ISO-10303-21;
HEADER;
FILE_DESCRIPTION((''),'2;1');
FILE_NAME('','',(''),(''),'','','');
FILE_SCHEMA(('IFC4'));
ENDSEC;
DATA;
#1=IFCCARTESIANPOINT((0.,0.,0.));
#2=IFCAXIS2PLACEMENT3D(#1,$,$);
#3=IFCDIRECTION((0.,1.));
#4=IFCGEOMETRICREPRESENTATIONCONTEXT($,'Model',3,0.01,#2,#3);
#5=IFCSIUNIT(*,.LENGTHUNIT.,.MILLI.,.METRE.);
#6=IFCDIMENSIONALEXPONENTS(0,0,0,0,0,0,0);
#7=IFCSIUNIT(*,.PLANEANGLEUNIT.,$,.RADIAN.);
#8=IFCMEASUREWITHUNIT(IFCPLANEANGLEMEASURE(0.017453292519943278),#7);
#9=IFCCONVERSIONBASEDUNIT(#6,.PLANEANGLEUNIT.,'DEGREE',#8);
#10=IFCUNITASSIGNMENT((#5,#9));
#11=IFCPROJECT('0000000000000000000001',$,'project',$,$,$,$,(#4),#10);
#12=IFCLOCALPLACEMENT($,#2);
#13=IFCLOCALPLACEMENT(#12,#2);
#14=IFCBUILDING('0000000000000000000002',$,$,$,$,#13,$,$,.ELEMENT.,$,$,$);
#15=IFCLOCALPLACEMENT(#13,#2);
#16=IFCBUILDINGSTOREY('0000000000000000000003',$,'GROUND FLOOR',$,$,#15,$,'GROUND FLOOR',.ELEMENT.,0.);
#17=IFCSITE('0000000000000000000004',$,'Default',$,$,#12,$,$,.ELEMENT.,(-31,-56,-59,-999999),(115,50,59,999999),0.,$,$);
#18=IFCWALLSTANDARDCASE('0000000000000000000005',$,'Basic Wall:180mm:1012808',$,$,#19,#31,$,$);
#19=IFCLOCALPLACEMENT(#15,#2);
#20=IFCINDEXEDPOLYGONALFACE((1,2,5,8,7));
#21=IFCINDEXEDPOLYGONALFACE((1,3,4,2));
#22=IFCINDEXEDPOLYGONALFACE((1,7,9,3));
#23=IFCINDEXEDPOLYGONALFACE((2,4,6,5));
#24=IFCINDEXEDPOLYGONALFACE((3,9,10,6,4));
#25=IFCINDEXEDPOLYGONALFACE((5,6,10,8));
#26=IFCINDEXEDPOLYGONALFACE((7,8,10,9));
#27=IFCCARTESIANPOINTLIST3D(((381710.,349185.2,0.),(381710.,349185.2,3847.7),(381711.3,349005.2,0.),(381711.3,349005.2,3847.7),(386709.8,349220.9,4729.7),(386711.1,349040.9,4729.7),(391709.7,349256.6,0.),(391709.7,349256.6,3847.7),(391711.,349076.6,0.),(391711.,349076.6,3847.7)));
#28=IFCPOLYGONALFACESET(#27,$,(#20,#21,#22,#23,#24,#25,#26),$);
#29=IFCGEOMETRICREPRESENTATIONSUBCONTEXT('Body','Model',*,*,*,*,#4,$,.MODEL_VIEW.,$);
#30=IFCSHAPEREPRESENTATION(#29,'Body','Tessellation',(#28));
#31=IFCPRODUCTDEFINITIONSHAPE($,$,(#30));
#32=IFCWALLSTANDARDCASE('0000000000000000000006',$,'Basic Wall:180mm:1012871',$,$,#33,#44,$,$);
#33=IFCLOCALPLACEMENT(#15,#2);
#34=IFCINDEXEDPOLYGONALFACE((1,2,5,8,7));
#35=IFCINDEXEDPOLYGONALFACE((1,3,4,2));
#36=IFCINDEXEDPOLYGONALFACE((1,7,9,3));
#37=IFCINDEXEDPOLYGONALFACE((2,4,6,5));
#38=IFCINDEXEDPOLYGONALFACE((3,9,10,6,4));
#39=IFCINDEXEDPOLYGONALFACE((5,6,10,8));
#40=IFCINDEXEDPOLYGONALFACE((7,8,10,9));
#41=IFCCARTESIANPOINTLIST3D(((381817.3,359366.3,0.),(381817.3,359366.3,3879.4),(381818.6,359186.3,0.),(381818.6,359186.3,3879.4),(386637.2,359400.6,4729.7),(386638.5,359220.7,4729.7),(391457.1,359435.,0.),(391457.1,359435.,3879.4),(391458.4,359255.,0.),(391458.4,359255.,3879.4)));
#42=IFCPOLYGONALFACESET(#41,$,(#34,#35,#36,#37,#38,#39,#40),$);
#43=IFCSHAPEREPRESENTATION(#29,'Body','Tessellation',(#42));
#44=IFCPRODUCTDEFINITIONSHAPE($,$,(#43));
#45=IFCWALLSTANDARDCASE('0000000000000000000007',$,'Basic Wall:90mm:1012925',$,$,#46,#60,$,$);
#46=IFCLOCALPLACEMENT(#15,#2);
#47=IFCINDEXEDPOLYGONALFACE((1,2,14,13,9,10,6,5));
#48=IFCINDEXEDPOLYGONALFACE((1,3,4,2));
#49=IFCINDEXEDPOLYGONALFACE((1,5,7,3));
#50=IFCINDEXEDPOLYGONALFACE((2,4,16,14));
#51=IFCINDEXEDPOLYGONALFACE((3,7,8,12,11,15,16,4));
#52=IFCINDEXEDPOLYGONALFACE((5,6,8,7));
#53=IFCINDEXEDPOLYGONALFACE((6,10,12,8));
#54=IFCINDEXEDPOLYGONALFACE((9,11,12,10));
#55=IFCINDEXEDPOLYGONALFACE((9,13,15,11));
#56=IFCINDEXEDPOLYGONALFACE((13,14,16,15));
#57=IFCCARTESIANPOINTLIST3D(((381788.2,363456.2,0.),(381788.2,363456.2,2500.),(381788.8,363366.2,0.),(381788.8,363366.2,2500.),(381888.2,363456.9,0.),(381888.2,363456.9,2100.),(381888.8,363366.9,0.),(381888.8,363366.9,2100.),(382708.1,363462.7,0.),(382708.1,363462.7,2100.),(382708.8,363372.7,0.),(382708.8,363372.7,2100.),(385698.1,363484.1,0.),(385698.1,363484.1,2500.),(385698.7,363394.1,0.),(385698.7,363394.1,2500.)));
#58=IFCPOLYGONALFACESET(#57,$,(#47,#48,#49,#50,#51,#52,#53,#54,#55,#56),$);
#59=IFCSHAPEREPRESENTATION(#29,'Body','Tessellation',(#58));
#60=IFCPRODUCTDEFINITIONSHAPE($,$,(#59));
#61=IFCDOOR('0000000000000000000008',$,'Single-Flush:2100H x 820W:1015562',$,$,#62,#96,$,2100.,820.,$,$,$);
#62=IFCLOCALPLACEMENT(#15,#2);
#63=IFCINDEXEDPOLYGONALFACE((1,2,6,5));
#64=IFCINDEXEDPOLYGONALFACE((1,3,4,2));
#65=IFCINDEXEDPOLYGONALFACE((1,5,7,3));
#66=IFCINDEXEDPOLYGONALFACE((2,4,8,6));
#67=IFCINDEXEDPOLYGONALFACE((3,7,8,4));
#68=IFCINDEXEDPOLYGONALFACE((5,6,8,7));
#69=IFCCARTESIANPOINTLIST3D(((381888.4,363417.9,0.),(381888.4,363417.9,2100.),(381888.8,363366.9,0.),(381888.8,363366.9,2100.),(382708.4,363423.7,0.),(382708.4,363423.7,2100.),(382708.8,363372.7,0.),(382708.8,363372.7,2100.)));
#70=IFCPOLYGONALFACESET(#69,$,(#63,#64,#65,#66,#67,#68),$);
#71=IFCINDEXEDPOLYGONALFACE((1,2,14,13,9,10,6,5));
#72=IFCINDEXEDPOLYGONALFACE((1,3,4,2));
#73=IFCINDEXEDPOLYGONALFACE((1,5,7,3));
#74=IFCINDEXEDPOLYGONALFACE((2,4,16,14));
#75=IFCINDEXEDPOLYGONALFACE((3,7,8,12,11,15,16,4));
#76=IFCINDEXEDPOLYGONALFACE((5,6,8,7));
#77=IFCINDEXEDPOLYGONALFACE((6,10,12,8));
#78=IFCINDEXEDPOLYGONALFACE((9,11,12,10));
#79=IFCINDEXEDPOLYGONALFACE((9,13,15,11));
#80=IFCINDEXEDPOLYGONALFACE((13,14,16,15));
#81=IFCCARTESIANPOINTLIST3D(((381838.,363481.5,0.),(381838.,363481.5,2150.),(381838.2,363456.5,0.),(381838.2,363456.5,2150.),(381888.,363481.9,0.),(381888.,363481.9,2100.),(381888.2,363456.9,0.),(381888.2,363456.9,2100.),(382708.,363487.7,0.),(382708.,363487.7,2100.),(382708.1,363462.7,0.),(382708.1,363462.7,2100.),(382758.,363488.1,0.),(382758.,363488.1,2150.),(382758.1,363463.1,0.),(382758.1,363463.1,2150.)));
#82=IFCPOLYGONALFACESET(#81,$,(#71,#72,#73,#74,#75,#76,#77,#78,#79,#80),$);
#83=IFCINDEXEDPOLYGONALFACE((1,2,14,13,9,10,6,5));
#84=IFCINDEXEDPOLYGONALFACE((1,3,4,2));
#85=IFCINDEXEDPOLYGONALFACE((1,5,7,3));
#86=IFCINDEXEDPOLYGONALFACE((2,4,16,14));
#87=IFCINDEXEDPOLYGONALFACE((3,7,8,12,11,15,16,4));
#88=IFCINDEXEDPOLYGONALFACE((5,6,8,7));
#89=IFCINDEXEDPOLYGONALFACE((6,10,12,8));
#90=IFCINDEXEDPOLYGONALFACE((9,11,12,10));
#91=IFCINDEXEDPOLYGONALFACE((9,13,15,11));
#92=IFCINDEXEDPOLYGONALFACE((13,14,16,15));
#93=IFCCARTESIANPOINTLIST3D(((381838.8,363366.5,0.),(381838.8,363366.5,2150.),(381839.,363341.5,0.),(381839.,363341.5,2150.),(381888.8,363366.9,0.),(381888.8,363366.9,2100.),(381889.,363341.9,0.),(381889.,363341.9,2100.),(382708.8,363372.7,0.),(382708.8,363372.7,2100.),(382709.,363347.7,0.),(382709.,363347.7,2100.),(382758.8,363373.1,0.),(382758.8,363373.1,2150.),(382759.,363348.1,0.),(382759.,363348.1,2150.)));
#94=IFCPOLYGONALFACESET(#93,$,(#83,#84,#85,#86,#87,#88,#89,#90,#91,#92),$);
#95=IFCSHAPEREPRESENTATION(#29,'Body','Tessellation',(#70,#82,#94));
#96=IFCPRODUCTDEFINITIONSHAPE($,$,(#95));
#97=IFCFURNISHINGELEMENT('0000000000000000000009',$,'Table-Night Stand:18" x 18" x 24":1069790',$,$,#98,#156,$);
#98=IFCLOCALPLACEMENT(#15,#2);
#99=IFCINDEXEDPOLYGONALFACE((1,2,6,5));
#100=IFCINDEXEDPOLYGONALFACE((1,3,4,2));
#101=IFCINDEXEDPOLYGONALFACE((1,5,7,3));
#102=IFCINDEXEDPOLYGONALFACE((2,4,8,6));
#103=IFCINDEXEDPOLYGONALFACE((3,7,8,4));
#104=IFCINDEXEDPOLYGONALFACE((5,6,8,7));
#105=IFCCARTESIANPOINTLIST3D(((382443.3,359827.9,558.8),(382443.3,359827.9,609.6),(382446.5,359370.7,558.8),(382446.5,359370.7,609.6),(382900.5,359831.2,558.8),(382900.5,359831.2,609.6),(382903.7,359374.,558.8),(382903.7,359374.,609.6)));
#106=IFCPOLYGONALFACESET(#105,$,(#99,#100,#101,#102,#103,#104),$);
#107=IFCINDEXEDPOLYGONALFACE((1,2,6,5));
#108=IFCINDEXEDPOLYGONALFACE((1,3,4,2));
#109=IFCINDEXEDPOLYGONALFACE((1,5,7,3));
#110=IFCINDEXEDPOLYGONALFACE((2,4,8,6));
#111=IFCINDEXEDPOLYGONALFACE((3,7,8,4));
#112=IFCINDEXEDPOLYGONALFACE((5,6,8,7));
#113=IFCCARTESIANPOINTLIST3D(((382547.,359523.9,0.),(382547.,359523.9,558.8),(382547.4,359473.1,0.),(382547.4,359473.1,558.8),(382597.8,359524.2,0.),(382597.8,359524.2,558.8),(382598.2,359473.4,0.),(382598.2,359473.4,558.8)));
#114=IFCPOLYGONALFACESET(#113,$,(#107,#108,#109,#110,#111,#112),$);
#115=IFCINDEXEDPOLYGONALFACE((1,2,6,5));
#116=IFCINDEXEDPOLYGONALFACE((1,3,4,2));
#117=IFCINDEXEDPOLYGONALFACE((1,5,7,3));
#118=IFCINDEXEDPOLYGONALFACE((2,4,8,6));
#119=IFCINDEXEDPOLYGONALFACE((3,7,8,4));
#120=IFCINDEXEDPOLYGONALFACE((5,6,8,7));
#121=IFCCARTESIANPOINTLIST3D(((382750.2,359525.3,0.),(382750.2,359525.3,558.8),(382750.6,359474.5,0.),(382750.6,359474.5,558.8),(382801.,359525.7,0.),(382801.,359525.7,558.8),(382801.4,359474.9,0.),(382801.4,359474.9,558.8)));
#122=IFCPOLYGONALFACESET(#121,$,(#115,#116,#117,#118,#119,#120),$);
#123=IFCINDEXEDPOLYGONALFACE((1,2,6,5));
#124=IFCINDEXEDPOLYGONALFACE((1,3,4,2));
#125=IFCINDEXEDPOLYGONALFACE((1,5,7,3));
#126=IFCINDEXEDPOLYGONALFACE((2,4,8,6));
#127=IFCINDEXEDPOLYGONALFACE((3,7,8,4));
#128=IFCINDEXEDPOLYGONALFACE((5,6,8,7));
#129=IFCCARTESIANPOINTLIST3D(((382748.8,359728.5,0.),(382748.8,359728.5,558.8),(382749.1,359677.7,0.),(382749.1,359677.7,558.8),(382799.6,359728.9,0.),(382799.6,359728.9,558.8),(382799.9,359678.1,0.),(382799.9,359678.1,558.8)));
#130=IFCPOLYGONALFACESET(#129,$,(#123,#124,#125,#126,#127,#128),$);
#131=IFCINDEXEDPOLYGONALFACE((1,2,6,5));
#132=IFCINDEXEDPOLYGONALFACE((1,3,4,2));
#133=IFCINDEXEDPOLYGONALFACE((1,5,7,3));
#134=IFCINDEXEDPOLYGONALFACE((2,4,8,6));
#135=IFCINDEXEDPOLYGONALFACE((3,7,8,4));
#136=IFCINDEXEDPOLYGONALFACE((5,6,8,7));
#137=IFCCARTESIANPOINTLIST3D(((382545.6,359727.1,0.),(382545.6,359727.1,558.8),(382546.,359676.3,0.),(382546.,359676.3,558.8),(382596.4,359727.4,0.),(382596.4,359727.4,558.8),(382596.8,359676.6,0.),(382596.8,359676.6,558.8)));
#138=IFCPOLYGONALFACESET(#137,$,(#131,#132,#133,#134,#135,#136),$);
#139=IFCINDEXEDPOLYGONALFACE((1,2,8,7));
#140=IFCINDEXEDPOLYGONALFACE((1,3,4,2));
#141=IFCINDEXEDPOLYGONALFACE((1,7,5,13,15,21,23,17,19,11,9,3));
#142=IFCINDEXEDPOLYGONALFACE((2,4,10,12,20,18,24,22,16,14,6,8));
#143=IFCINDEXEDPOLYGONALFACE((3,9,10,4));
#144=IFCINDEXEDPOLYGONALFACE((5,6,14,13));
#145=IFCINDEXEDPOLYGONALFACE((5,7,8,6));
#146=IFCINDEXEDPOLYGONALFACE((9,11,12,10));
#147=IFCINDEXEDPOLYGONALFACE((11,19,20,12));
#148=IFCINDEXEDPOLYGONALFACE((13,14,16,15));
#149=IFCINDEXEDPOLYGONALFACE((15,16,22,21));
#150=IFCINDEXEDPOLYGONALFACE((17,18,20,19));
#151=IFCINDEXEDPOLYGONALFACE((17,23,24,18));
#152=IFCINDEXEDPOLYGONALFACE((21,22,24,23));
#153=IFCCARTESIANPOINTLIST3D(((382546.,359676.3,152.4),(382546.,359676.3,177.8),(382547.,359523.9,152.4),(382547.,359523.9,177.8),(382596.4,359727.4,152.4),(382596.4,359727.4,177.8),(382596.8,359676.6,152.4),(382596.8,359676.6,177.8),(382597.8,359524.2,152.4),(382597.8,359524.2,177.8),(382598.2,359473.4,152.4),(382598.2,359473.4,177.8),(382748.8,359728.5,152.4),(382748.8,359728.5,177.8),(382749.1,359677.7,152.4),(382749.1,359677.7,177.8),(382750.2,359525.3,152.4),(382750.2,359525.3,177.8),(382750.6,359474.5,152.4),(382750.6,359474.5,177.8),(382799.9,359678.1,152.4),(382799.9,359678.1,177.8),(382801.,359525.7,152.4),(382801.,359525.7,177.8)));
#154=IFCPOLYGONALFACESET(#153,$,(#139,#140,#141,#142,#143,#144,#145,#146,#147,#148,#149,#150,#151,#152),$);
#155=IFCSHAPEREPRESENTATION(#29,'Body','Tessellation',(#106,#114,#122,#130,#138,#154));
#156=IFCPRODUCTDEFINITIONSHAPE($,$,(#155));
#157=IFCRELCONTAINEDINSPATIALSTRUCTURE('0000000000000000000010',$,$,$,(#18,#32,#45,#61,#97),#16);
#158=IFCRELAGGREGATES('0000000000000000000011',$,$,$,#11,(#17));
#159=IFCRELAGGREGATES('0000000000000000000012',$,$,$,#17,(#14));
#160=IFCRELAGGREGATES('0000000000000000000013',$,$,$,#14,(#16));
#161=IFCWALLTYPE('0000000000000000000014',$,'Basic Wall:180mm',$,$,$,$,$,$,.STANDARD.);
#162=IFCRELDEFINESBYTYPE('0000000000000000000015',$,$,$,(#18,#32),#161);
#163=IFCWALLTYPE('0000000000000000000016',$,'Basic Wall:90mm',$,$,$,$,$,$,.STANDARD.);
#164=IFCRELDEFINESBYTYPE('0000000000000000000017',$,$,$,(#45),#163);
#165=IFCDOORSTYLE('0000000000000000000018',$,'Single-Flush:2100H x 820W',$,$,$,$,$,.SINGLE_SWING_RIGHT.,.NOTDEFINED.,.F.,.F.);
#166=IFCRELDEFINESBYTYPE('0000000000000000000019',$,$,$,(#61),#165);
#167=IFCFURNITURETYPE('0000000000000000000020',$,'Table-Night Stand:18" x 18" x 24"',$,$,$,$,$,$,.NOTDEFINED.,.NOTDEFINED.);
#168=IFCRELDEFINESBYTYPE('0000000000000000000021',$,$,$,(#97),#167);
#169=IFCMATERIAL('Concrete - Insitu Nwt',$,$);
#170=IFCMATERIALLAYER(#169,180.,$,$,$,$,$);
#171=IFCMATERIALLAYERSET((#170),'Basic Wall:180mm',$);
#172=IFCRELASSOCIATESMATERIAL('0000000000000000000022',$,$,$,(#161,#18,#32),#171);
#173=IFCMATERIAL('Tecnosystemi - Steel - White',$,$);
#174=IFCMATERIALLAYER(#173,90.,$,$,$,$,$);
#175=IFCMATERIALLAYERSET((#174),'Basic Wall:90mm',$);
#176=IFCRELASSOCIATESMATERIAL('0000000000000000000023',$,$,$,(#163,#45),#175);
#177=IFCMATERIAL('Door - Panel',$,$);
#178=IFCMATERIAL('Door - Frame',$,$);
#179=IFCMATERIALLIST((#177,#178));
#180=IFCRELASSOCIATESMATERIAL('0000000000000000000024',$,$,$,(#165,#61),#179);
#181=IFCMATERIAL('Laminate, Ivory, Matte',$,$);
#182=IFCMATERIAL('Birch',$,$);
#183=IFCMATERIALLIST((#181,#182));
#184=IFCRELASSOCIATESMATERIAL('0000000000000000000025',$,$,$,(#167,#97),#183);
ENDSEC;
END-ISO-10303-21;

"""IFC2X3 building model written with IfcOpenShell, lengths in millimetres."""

from ifc_helpers import new_model, entity, si_unit, converted_unit, direction, frame, frame_2d, origin, origin_2d_with_axis, place, context, subcontext, project, spatial, polyline, rectangle, outline, extrude, clip, bounded_halfspace, source, transform, mapped, material, material_list, layer, layer_set, layer_usage, type_object, type_shapes, element, fill, save


model = new_model("IFC2X3")

# Units and contexts
model_context = context("Model", 3, precision=0.01, world=origin(), true_north=direction((0.0, 1.0)))
body_context = subcontext(model_context, "Body", "Model", "MODEL_VIEW")
ifc_project = project(units=[si_unit("LENGTHUNIT", "METRE", prefix="MILLI"), converted_unit("PLANEANGLEUNIT", "DEGREE", entity("IfcPlaneAngleMeasure", 0.017453292519943278), si_unit("PLANEANGLEUNIT", "RADIAN"), dimensions=[0, 0, 0, 0, 0, 0, 0])], contexts=[model_context])

# Site, building, storey
site_placement = place(None, origin())
site = spatial("IfcSite", under=ifc_project, at=site_placement, Name="Default", CompositionType="ELEMENT", RefLatitude=(-31, -56, -59, -999999), RefLongitude=(115, 50, 59, 999999), RefElevation=0.0)
building_placement = place(site_placement, origin())
building = spatial("IfcBuilding", under=site, at=building_placement, CompositionType="ELEMENT")
storey_placement = place(building_placement, origin())
storey = spatial("IfcBuildingStorey", under=building, at=storey_placement, Name="GROUND FLOOR", LongName="GROUND FLOOR", CompositionType="ELEMENT", Elevation=0.0)

# Shared definitions
ifc_material_1 = material(Name="Concrete - Insitu Nwt")

# Wall
ifc_layer_1 = layer(ifc_material_1, 180.0)
ifc_layer_set_1 = layer_set([ifc_layer_1], Name="Basic Wall:180mm")
ifc_layer_usage_1 = layer_usage(ifc_layer_set_1, "AXIS2", "POSITIVE", -90.0)
wall_type_1 = type_object("IfcWallType", Name="Basic Wall:180mm", PredefinedType="STANDARD", material=ifc_layer_set_1)
wall_1_placement = place(storey_placement, frame((381710.6, 349095.2, 0.0), z_axis=(0.0, 0.0, 1.0), x_axis=(0.999975, 0.007134, 0.0)))
element("IfcWallStandardCase", 1, at=wall_1_placement, inside=storey, type_object=wall_type_1, material=ifc_layer_usage_1, Name="Basic Wall:180mm:1012808", context=body_context, shape_type="Clipping", body=[
    clip(clip(extrude(rectangle(XDim=10000.0, YDim=180.0, at=frame_2d((5000.0, 0.0), x_axis=(-1.0, 0.0))), origin(), (0.0, 0.0, 1.0), 4729.7), bounded_halfspace(frame((0.0, -90.0, 3847.7), z_axis=(0.173718, 0.0, -0.984795), x_axis=(0.0, 1.0, 0.0)), True, frame((0.0, -90.0, 3847.7)), polyline([(0.0, 0.0), (5000.0, 0.0), (5000.0, 180.0), (180.0, 180.0), (0.0, 180.0), (0.0, 0.0)]))), bounded_halfspace(frame((5000.0, -90.0, 4729.7), z_axis=(-0.173718, 0.0, -0.984795), x_axis=(0.0, 1.0, 0.0)), True, frame((5000.0, -90.0, 4729.7)), polyline([(0.0, 0.0), (5000.0, 0.0), (5000.0, 180.0), (4820.0, 180.0), (0.0, 180.0), (0.0, 0.0)]))),
])

# Shared definitions
ifc_material_2 = material(Name="Door - Panel")
ifc_material_3 = material(Name="Door - Frame")
ifc_material_list_1 = material_list([ifc_material_2, ifc_material_3])

# Wall
ifc_layer_usage_2 = layer_usage(ifc_layer_set_1, "AXIS2", "NEGATIVE", 90.0)
wall_2_placement = place(storey_placement, frame((381818.0, 359276.3, 0.0), z_axis=(0.0, 0.0, 1.0), x_axis=(0.999975, 0.007134, 0.0)))
element("IfcWallStandardCase", 2, at=wall_2_placement, inside=storey, type_object=wall_type_1, material=ifc_layer_usage_2, Name="Basic Wall:180mm:1012871", context=body_context, shape_type="Clipping", body=[
    clip(clip(extrude(rectangle(XDim=9640.0, YDim=180.0, at=frame_2d((4820.0, 0.0), x_axis=(-1.0, 0.0))), origin(), (0.0, 0.0, 1.0), 4729.7), bounded_halfspace(frame((0.0, -90.0, 3879.4), z_axis=(0.173718, 0.0, -0.984795), x_axis=(0.0, 1.0, 0.0)), True, frame((0.0, -90.0, 3879.4)), polyline([(0.0, 0.0), (4820.0, 0.0), (4820.0, 180.0), (0.0, 180.0), (0.0, 0.0)]))), bounded_halfspace(frame((4820.0, -90.0, 4729.7), z_axis=(-0.173718, 0.0, -0.984795), x_axis=(0.0, 1.0, 0.0)), True, frame((4820.0, -90.0, 4729.7)), polyline([(0.0, 0.0), (4820.0, 0.0), (4820.0, 180.0), (0.0, 180.0), (0.0, 0.0)]))),
])

# Wall, opening, door
ifc_material_4 = material(Name="Tecnosystemi - Steel - White")
ifc_layer_2 = layer(ifc_material_4, 90.0)
ifc_layer_set_2 = layer_set([ifc_layer_2], Name="Basic Wall:90mm")
ifc_layer_usage_3 = layer_usage(ifc_layer_set_2, "AXIS2", "NEGATIVE", 45.0)
wall_type_2 = type_object("IfcWallType", Name="Basic Wall:90mm", PredefinedType="STANDARD", material=ifc_layer_set_2)
wall_3_placement = place(storey_placement, frame((381788.5, 363411.2, 0.0), z_axis=(0.0, 0.0, 1.0), x_axis=(0.999975, 0.007134, 0.0)))
wall_3 = element("IfcWallStandardCase", 3, at=wall_3_placement, inside=storey, type_object=wall_type_2, material=ifc_layer_usage_3, Name="Basic Wall:90mm:1012925", context=body_context, shape_type="SweptSolid", body=[
    extrude(rectangle(XDim=3910.0, YDim=90.0, at=frame_2d((1955.0, 0.0), x_axis=(1.0, 0.0))), origin(), (0.0, 0.0, 1.0), 2500.0),
])
opening_1_placement = place(wall_3_placement, frame((920.0, 45.0, 0.0)))
opening_1 = element("IfcOpeningElement", 4, at=opening_1_placement, cuts=wall_3, ObjectType="Opening", context=body_context, shape_type="SweptSolid", body=[
    extrude(rectangle(XDim=820.0, YDim=2100.0, at=frame_2d((1050.0, 410.0), x_axis=(0.0, 1.0))), frame((0.0, 0.0, 0.0), z_axis=(0.0, -1.0, 0.0), x_axis=(0.0, 0.0, 1.0)), (0.0, 0.0, 1.0), 90.0),
])
door_style_1 = type_object("IfcDoorStyle", Name="Single-Flush:2100H x 820W", ConstructionType="NOTDEFINED", OperationType="SINGLE_SWING_RIGHT", ParameterTakesPrecedence=False, Sizeable=False, material=ifc_material_list_1)
shared_shape_1 = source(origin(), body_context, "Body", "SweptSolid", [
    extrude(rectangle(XDim=51.0, YDim=820.0, at=frame_2d((0.0, 0.0), x_axis=(1.0, 0.0))), frame((410.0, 64.5, 0.0), z_axis=(0.0, 0.0, 1.0), x_axis=(0.0, 1.0, 0.0)), (0.0, 0.0, 1.0), 2100.0),
    extrude(outline(polyline([(-1087.5, -460.0), (1062.5, -460.0), (1062.5, -410.0), (-1037.5, -410.0), (-1037.5, 410.0), (1062.5, 410.0), (1062.5, 460.0), (-1087.5, 460.0), (-1087.5, -460.0)])), frame((410.0, -25.0, 1062.5), z_axis=(0.0, 1.0, 0.0), x_axis=(0.0, 0.0, -1.0)), (0.0, 0.0, 1.0), 25.0),
    extrude(outline(polyline([(-460.0, -1087.5), (460.0, -1087.5), (460.0, 1062.5), (410.0, 1062.5), (410.0, -1037.5), (-410.0, -1037.5), (-410.0, 1062.5), (-460.0, 1062.5), (-460.0, -1087.5)])), frame((410.0, 90.0, 1062.5), z_axis=(0.0, 1.0, 0.0), x_axis=(1.0, 0.0, 0.0)), (0.0, 0.0, 1.0), 25.0),
])
type_shapes(door_style_1, [shared_shape_1])
door_1_placement = place(opening_1_placement, frame((0.0, 0.0, 0.0), z_axis=(0.0, 0.0, 1.0), x_axis=(-1.0, 0.0, 0.0)))
door_1 = element("IfcDoor", 5, at=door_1_placement, inside=storey, type_object=door_style_1, material=ifc_material_list_1, Name="Single-Flush:2100H x 820W:1015562", OverallHeight=2100.0, OverallWidth=820.0, context=body_context, shape_type="MappedRepresentation", body=[
    mapped(shared_shape_1, transform((0.0, 0.0, 0.0), scale=1.0)),
])
fill(opening_1, door_1)

# Furnishing element
ifc_material_5 = material(Name="Laminate, Ivory, Matte")
ifc_material_6 = material(Name="Birch")
ifc_material_list_2 = material_list([ifc_material_5, ifc_material_6])
furniture_type_1 = type_object("IfcFurnitureType", Name="Table-Night Stand:18\" x 18\" x 24\"", AssemblyPlace="NOTDEFINED", material=ifc_material_list_2)
shared_shape_2 = source(origin(), body_context, "Body", "SweptSolid", [
    extrude(rectangle(XDim=457.2, YDim=457.2, at=origin_2d_with_axis()), frame((232.3, 228.6, 558.8), z_axis=(0.0, 0.0, 1.0), x_axis=(0.0, 1.0, 0.0)), (0.0, 0.0, 1.0), 50.8),
    extrude(rectangle(XDim=50.8, YDim=50.8, at=origin_2d_with_axis()), frame((333.9, 330.2, 0.0), z_axis=(0.0, 0.0, 1.0), x_axis=(-1.0, 0.0, 0.0)), (0.0, 0.0, 1.0), 558.8),
    extrude(rectangle(XDim=50.8, YDim=50.8, at=frame_2d((0.0, 0.0), x_axis=(1.0, 0.0))), frame((130.7, 330.2, 0.0), z_axis=(0.0, 0.0, 1.0), x_axis=(-1.0, 0.0, 0.0)), (0.0, 0.0, 1.0), 558.8),
    extrude(rectangle(XDim=50.8, YDim=50.8, at=frame_2d((0.0, 0.0), x_axis=(1.0, 0.0))), frame((130.7, 127.0, 0.0), z_axis=(0.0, 0.0, 1.0), x_axis=(-1.0, 0.0, 0.0)), (0.0, 0.0, 1.0), 558.8),
    extrude(rectangle(XDim=50.8, YDim=50.8, at=frame_2d((0.0, 0.0), x_axis=(1.0, 0.0))), frame((333.9, 127.0, 0.0), z_axis=(0.0, 0.0, 1.0), x_axis=(-1.0, 0.0, 0.0)), (0.0, 0.0, 1.0), 558.8),
    extrude(outline(polyline([(-127.0, 76.2), (-127.0, -76.2), (-76.2, -76.2), (-76.2, -127.0), (76.2, -127.0), (76.2, -76.2), (127.0, -76.2), (127.0, 76.2), (76.2, 76.2), (76.2, 127.0), (-76.2, 127.0), (-76.2, 76.2), (-127.0, 76.2)])), frame((232.3, 228.6, 152.4), z_axis=(0.0, 0.0, -1.0), x_axis=(0.0, -1.0, 0.0)), (0.0, 0.0, -1.0), 25.4),
])
type_shapes(furniture_type_1, [shared_shape_2])
furnishing_1_placement = place(storey_placement, frame((382904.2, 359831.2, 0.0), z_axis=(0.0, 0.0, 1.0), x_axis=(-0.999975, -0.007134, 0.0)))
element("IfcFurnishingElement", 6, at=furnishing_1_placement, inside=storey, type_object=furniture_type_1, material=ifc_material_list_2, Name="Table-Night Stand:18\" x 18\" x 24\":1069790", context=body_context, shape_type="MappedRepresentation", body=[
    mapped(shared_shape_2, transform((0.0, 0.0, 0.0), scale=1.0)),
])

save(model, "model.ifc")
